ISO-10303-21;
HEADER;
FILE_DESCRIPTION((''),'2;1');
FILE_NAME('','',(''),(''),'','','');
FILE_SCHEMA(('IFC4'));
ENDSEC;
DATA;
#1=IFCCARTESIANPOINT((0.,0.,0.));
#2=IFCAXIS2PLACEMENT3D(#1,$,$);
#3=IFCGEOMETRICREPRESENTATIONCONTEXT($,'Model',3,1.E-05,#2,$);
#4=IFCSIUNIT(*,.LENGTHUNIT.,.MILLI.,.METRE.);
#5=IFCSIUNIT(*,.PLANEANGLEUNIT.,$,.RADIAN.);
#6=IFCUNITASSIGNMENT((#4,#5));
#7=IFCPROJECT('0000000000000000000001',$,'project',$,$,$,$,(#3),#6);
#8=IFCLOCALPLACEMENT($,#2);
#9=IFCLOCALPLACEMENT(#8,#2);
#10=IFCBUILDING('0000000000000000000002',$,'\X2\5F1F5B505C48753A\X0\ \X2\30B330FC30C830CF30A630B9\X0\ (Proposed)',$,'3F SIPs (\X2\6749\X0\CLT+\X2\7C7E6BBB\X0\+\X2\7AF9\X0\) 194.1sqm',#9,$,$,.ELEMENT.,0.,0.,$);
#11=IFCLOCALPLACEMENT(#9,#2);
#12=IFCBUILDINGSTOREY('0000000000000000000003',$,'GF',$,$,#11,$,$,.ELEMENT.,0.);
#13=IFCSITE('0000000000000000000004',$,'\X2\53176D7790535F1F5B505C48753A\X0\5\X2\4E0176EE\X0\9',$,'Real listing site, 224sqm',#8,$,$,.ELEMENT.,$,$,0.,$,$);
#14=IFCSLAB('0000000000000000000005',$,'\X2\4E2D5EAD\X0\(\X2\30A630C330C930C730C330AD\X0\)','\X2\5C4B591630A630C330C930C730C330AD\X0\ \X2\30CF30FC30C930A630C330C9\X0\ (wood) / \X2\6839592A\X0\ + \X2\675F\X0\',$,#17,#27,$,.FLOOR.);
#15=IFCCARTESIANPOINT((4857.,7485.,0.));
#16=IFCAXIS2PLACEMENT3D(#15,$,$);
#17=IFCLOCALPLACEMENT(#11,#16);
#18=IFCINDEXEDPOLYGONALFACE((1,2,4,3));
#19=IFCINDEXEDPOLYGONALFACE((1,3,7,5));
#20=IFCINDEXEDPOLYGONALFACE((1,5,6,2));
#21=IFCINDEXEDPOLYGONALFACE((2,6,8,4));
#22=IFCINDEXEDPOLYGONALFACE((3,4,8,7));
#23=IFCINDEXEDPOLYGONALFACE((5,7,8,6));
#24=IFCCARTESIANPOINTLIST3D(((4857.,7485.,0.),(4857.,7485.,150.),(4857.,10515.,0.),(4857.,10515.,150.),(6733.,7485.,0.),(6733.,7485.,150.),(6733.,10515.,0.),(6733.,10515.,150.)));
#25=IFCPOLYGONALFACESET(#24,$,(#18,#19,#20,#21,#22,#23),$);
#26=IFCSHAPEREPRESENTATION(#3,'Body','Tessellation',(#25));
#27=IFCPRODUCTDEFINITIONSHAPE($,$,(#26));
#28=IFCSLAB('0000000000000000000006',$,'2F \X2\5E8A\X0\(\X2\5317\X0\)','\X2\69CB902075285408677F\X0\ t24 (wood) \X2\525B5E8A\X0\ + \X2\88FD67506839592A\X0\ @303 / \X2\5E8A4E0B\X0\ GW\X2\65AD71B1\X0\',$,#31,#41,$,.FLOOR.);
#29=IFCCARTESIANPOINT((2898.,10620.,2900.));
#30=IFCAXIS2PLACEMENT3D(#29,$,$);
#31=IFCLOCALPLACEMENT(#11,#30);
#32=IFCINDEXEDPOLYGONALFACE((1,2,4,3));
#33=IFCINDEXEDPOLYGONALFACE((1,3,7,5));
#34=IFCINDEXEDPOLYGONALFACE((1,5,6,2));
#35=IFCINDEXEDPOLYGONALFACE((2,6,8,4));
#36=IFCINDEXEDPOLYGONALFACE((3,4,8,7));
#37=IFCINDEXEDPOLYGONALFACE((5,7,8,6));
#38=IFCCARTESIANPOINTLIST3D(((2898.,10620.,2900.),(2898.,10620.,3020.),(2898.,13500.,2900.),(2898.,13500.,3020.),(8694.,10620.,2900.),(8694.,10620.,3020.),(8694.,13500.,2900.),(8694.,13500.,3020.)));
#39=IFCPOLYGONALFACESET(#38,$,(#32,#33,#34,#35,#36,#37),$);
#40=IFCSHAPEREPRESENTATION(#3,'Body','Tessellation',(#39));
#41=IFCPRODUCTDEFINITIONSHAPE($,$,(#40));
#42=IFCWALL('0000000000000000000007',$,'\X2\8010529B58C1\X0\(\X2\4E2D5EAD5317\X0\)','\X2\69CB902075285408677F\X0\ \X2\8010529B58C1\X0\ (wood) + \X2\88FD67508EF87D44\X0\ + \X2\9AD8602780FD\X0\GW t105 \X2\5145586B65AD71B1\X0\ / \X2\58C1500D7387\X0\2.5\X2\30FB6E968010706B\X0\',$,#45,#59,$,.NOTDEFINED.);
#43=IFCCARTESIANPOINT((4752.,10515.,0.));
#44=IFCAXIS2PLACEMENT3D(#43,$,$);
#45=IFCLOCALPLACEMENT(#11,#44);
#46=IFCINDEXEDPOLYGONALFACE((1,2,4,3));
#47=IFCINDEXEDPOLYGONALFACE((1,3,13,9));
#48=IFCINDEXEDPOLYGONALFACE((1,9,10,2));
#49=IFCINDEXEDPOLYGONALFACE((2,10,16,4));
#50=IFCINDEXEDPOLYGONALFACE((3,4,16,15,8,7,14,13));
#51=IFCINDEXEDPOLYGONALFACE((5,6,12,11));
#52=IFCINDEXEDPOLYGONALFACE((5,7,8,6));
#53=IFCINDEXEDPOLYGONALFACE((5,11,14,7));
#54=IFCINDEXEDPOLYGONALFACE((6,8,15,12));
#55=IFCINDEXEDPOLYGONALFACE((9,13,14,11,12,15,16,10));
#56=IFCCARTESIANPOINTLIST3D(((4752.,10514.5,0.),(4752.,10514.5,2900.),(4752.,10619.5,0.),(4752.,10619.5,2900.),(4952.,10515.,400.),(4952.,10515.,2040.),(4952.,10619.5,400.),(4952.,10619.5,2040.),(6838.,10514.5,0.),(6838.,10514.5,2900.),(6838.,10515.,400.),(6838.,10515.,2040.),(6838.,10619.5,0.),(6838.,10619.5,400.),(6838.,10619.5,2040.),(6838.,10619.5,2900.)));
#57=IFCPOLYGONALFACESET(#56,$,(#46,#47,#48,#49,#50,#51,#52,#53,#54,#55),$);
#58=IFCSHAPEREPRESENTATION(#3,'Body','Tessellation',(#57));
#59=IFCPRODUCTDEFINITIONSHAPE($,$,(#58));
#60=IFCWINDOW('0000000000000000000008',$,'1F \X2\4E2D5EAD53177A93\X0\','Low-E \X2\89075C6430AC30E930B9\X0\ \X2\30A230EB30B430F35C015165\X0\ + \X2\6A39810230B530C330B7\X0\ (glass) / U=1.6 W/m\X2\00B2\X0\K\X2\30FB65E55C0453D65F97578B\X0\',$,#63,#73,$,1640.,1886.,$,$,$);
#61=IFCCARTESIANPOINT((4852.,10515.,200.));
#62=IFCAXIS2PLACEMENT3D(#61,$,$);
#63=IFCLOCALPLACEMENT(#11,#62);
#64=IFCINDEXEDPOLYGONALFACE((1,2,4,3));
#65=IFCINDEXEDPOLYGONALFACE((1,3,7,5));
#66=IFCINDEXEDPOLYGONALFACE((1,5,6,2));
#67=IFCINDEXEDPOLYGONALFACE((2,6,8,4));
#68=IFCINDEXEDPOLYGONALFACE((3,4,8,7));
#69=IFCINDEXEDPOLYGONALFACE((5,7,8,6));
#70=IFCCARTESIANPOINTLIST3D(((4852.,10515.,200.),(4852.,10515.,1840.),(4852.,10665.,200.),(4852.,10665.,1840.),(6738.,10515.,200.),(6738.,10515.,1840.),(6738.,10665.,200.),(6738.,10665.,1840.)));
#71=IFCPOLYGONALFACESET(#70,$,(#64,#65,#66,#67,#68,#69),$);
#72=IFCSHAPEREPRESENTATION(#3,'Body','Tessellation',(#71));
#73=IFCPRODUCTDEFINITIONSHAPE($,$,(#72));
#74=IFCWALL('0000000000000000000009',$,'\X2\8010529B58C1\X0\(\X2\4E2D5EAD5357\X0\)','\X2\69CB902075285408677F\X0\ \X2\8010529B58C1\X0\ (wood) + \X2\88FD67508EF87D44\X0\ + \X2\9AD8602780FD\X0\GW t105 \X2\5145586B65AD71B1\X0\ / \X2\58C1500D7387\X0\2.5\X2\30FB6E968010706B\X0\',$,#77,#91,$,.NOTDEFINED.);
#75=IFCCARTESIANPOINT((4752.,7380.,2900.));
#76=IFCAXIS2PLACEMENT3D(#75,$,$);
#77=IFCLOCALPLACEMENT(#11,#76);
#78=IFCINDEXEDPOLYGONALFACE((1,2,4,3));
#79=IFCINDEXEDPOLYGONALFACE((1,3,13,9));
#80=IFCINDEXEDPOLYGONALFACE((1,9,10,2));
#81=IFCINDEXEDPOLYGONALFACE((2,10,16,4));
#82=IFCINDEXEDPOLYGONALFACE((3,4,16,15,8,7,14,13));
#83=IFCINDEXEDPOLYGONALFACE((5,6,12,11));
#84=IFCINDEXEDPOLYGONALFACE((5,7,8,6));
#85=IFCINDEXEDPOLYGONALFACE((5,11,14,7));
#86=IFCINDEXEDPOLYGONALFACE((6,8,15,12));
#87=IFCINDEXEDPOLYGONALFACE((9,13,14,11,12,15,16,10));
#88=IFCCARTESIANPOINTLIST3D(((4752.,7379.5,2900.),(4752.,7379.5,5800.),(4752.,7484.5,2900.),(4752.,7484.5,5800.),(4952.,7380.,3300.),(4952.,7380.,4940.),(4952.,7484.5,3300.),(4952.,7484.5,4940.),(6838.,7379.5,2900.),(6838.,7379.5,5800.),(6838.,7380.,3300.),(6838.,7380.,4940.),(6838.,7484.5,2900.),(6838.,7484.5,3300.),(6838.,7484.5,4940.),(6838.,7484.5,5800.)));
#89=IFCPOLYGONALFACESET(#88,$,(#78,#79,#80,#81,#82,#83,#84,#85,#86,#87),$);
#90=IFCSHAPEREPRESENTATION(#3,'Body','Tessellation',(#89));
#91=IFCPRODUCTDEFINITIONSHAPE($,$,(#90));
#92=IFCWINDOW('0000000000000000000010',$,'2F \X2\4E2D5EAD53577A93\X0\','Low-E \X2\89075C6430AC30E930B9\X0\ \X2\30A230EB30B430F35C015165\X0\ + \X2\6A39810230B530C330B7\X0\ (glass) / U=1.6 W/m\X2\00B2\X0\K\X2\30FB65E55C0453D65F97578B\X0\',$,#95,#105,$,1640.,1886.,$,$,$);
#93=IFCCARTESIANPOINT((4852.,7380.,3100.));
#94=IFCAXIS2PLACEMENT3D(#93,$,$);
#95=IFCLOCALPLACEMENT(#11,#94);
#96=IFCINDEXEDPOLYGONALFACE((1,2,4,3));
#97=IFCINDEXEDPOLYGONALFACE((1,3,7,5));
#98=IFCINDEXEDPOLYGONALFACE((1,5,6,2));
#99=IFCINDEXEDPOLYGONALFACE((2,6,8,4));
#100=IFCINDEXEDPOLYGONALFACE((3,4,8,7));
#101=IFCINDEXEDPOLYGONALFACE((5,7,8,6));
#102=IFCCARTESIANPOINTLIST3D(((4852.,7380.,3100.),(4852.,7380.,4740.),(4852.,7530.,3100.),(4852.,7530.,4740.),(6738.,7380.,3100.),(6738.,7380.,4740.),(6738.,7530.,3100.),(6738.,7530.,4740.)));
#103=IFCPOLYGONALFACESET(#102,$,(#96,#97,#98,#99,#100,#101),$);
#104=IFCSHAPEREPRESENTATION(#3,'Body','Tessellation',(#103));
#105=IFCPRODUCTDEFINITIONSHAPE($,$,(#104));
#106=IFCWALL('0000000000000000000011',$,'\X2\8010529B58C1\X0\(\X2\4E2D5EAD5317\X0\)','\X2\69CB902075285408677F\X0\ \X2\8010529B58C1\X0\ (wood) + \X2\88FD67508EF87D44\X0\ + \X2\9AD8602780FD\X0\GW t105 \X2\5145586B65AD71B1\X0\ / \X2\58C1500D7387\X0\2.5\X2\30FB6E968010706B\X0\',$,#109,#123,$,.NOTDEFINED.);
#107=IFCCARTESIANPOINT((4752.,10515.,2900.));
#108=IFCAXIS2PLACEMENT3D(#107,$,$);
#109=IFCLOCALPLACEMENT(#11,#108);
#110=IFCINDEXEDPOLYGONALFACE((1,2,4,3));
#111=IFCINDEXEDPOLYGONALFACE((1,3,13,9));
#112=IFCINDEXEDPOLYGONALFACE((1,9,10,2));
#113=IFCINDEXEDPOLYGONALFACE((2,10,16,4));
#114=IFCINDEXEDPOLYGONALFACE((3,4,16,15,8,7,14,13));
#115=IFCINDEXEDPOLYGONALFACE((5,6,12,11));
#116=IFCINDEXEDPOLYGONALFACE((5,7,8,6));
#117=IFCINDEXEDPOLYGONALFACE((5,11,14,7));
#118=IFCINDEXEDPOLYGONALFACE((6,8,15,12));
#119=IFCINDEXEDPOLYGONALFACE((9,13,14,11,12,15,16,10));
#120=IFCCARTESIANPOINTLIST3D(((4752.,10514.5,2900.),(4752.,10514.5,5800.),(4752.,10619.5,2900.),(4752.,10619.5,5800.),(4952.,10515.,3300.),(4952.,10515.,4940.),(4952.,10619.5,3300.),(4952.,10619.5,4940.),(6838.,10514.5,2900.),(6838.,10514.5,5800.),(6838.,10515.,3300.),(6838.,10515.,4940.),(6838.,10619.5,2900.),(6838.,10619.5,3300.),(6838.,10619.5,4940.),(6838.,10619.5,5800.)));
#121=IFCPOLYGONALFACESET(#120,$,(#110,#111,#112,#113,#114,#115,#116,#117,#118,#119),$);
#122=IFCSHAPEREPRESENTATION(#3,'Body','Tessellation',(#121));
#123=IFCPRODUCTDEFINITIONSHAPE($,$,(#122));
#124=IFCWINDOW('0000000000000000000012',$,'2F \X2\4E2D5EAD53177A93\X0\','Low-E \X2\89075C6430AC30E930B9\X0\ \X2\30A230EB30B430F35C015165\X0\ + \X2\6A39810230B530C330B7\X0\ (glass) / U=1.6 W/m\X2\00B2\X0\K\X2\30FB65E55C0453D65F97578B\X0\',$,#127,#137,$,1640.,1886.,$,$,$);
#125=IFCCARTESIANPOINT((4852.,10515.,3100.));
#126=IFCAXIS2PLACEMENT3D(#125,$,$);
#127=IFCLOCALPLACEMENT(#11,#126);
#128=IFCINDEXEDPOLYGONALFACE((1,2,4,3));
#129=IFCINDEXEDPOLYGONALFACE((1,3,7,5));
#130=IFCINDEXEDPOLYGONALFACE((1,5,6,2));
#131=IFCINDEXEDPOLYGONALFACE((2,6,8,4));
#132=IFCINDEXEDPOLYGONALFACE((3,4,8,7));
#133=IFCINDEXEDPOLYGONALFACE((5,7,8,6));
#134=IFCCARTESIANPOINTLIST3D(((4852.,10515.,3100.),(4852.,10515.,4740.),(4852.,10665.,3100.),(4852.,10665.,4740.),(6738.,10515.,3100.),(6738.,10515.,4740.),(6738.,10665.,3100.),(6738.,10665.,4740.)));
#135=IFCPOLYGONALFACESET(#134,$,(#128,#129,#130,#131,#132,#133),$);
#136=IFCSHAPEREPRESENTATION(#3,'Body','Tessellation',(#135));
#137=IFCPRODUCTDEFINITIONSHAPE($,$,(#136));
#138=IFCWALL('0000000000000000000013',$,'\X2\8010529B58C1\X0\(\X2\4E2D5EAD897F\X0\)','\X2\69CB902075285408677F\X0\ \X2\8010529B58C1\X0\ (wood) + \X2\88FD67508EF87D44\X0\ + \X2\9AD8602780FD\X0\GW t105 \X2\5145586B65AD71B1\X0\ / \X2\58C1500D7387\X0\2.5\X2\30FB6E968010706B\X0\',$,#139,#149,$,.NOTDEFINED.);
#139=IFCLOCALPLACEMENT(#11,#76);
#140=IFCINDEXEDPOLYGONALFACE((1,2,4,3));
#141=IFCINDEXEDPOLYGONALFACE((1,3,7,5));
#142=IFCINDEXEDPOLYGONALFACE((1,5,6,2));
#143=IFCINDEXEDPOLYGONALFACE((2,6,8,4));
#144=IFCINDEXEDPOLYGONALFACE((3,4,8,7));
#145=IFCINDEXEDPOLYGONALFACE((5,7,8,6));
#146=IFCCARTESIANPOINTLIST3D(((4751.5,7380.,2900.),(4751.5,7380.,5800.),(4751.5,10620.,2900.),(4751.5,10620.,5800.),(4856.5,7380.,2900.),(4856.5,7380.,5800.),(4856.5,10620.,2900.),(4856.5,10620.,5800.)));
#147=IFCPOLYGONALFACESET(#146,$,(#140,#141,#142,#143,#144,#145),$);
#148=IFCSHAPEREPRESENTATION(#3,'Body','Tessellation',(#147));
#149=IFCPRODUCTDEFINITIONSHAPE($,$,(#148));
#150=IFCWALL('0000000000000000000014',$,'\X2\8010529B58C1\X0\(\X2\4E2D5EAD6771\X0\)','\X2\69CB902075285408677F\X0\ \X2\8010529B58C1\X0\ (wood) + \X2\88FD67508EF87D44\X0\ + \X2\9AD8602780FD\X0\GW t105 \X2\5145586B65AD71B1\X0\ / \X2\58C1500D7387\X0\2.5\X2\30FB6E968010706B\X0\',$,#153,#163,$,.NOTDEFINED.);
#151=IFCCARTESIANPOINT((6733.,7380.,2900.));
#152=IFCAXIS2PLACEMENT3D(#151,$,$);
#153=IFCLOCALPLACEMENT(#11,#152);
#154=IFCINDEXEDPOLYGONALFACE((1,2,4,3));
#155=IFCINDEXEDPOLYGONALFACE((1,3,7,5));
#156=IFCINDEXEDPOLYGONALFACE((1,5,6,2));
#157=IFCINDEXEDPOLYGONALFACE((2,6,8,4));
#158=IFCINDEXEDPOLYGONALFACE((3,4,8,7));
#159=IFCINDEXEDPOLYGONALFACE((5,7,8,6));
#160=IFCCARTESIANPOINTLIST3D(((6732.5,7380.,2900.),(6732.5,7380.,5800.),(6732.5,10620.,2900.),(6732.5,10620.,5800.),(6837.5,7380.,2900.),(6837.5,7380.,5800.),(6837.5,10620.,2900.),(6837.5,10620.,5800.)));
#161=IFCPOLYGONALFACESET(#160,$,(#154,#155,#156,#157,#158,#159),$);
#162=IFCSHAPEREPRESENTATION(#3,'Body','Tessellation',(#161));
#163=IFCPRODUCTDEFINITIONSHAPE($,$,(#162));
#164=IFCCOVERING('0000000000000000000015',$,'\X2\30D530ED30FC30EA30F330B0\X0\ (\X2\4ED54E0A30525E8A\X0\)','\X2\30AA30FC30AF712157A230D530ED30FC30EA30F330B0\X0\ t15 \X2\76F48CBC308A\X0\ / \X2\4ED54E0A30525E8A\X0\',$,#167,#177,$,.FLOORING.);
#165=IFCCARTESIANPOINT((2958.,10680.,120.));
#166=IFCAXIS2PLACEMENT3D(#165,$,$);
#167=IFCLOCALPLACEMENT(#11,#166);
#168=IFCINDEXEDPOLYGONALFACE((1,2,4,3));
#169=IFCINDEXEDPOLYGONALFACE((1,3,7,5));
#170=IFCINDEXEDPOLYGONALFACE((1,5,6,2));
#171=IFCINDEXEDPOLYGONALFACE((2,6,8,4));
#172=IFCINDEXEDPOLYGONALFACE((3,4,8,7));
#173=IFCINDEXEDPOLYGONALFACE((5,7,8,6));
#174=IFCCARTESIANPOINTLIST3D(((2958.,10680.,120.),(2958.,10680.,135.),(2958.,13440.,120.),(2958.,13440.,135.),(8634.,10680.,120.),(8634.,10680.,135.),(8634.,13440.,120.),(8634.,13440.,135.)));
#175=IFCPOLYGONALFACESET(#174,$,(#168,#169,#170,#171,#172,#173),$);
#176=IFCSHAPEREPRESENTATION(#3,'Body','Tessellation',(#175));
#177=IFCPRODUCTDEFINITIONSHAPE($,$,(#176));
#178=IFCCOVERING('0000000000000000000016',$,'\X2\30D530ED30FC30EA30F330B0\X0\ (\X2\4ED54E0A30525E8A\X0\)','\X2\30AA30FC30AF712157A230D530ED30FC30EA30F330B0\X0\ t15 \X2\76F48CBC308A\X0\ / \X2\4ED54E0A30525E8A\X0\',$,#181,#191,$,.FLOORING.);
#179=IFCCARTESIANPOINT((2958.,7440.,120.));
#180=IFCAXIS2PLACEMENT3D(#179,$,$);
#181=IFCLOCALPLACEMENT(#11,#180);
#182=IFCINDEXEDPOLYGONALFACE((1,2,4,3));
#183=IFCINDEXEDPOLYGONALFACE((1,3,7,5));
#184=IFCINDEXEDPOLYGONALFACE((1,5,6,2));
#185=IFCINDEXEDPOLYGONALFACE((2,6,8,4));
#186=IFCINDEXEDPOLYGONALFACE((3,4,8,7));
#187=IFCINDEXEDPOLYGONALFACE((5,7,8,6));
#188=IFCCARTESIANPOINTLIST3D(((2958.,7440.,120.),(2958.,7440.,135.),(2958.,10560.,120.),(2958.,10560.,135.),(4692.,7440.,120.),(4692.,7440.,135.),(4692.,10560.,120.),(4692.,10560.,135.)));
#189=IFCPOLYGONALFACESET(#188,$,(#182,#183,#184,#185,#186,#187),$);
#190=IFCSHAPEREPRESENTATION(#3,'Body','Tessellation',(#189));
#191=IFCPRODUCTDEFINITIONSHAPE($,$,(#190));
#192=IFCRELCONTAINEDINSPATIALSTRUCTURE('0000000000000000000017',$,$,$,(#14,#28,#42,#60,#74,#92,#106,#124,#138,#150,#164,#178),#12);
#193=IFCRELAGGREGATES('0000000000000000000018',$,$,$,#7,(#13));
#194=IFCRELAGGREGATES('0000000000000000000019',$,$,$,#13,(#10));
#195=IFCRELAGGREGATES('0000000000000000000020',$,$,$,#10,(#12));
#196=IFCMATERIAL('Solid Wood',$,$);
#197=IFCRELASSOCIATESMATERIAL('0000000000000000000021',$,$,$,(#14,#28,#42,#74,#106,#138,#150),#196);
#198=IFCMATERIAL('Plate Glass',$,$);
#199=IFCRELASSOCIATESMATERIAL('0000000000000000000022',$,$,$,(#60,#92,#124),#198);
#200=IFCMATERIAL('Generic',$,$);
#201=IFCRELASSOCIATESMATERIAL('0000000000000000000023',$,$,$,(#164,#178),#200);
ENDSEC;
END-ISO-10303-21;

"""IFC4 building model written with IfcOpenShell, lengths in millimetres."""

from ifc_helpers import new_model, si_unit, frame, frame_2d, origin, place, context, project, spatial, rectangle, extrude, material, element, fill, save


model = new_model("IFC4")

# Units and contexts
model_context = context("Model", 3, precision=1e-05, world=origin())
ifc_project = project(units=[si_unit("LENGTHUNIT", "METRE", prefix="MILLI"), si_unit("PLANEANGLEUNIT", "RADIAN")], contexts=[model_context])

# Site, building, storey
site_placement = place(None, origin())
site = spatial("IfcSite", under=ifc_project, at=site_placement, Name="北海道弟子屈町5丁目9", ObjectType="Real listing site, 224sqm", CompositionType="ELEMENT", RefElevation=0.0)
building_placement = place(site_placement, origin())
building = spatial("IfcBuilding", under=site, at=building_placement, Name="弟子屈町 コートハウス (Proposed)", ObjectType="3F SIPs (杉CLT+籾殻+竹) 194.1sqm", CompositionType="ELEMENT", ElevationOfRefHeight=0.0, ElevationOfTerrain=0.0)
storey_placement = place(building_placement, origin())
storey = spatial("IfcBuildingStorey", under=building, at=storey_placement, Name="GF", CompositionType="ELEMENT", Elevation=0.0)

# Slabs
ifc_material_1 = material(Name="Solid Wood")
slab_1_placement = place(storey_placement, frame((4857.0, 7485.0, 0.0)))
element("IfcSlab", 1, at=slab_1_placement, inside=storey, material=ifc_material_1, Name="中庭(ウッドデッキ)", Description="屋外ウッドデッキ ハードウッド (wood) / 根太 + 束", PredefinedType="FLOOR", context=model_context, shape_type="SweptSolid", body=[
    extrude(rectangle(XDim=1876.0, YDim=3030.0, at=frame_2d((938.0, 1515.0))), frame((4857.0, 7485.0, 0.0)), (0.0, 0.0, 1.0), 150.0),
])
slab_2_placement = place(storey_placement, frame((2898.0, 10620.0, 2900.0)))
element("IfcSlab", 2, at=slab_2_placement, inside=storey, material=ifc_material_1, Name="2F 床(北)", Description="構造用合板 t24 (wood) 剛床 + 製材根太 @303 / 床下 GW断熱", PredefinedType="FLOOR", context=model_context, shape_type="SweptSolid", body=[
    extrude(rectangle(XDim=5796.0, YDim=2880.0, at=frame_2d((2898.0, 1440.0))), frame((2898.0, 10620.0, 2900.0)), (0.0, 0.0, 1.0), 120.0),
])

# Wall, opening, window
wall_1_placement = place(storey_placement, frame((4752.0, 10515.0, 0.0)))
wall_1 = element("IfcWall", 3, at=wall_1_placement, inside=storey, material=ifc_material_1, Name="耐力壁(中庭北)", Description="構造用合板 耐力壁 (wood) + 製材軸組 + 高性能GW t105 充填断熱 / 壁倍率2.5・準耐火", PredefinedType="NOTDEFINED", context=model_context, shape_type="SweptSolid", body=[
    extrude(rectangle(XDim=2086.0, YDim=105.0, at=frame_2d((1043.0, 52.0))), frame((4752.0, 10515.0, 0.0)), (0.0, 0.0, 1.0), 2900.0),
])
opening_1_placement = place(storey_placement, frame((4852.0, 10515.0, 200.0)))
opening_1 = element("IfcOpeningElement", 4, at=opening_1_placement, cuts=wall_1, PredefinedType="NOTDEFINED", context=model_context, shape_type="SweptSolid", body=[
    extrude(rectangle(XDim=1886.0, YDim=150.0, at=frame_2d((943.0, 75.0))), frame((4852.0, 10515.0, 200.0)), (0.0, 0.0, 1.0), 1640.0),
])
ifc_material_2 = material(Name="Plate Glass")
window_1_placement = place(storey_placement, frame((4852.0, 10515.0, 200.0)))
window_1 = element("IfcWindow", 5, at=window_1_placement, inside=storey, material=ifc_material_2, Name="1F 中庭北窓", Description="Low-E 複層ガラス アルゴン封入 + 樹脂サッシ (glass) / U=1.6 W/m²K・日射取得型", OverallHeight=1640.0, OverallWidth=1886.0, context=model_context, shape_type="SweptSolid", body=[
    extrude(rectangle(XDim=1886.0, YDim=150.0, at=frame_2d((943.0, 75.0))), frame((4852.0, 10515.0, 200.0)), (0.0, 0.0, 1.0), 1640.0),
])
fill(opening_1, window_1)

# Walls, openings, windows
wall_2_placement = place(storey_placement, frame((4752.0, 7380.0, 2900.0)))
wall_2 = element("IfcWall", 6, at=wall_2_placement, inside=storey, material=ifc_material_1, Name="耐力壁(中庭南)", Description="構造用合板 耐力壁 (wood) + 製材軸組 + 高性能GW t105 充填断熱 / 壁倍率2.5・準耐火", PredefinedType="NOTDEFINED", context=model_context, shape_type="SweptSolid", body=[
    extrude(rectangle(XDim=2086.0, YDim=105.0, at=frame_2d((1043.0, 52.0))), frame((4752.0, 7380.0, 2900.0)), (0.0, 0.0, 1.0), 2900.0),
])
opening_2_placement = place(storey_placement, frame((4852.0, 7380.0, 3100.0)))
opening_2 = element("IfcOpeningElement", 7, at=opening_2_placement, cuts=wall_2, PredefinedType="NOTDEFINED", context=model_context, shape_type="SweptSolid", body=[
    extrude(rectangle(XDim=1886.0, YDim=150.0, at=frame_2d((943.0, 75.0))), frame((4852.0, 7380.0, 3100.0)), (0.0, 0.0, 1.0), 1640.0),
])
window_2_placement = place(storey_placement, frame((4852.0, 7380.0, 3100.0)))
window_2 = element("IfcWindow", 8, at=window_2_placement, inside=storey, material=ifc_material_2, Name="2F 中庭南窓", Description="Low-E 複層ガラス アルゴン封入 + 樹脂サッシ (glass) / U=1.6 W/m²K・日射取得型", OverallHeight=1640.0, OverallWidth=1886.0, context=model_context, shape_type="SweptSolid", body=[
    extrude(rectangle(XDim=1886.0, YDim=150.0, at=frame_2d((943.0, 75.0))), frame((4852.0, 7380.0, 3100.0)), (0.0, 0.0, 1.0), 1640.0),
])
fill(opening_2, window_2)
wall_3_placement = place(storey_placement, frame((4752.0, 10515.0, 2900.0)))
wall_3 = element("IfcWall", 9, at=wall_3_placement, inside=storey, material=ifc_material_1, Name="耐力壁(中庭北)", Description="構造用合板 耐力壁 (wood) + 製材軸組 + 高性能GW t105 充填断熱 / 壁倍率2.5・準耐火", PredefinedType="NOTDEFINED", context=model_context, shape_type="SweptSolid", body=[
    extrude(rectangle(XDim=2086.0, YDim=105.0, at=frame_2d((1043.0, 52.0))), frame((4752.0, 10515.0, 2900.0)), (0.0, 0.0, 1.0), 2900.0),
])
opening_3_placement = place(storey_placement, frame((4852.0, 10515.0, 3100.0)))
opening_3 = element("IfcOpeningElement", 10, at=opening_3_placement, cuts=wall_3, PredefinedType="NOTDEFINED", context=model_context, shape_type="SweptSolid", body=[
    extrude(rectangle(XDim=1886.0, YDim=150.0, at=frame_2d((943.0, 75.0))), frame((4852.0, 10515.0, 3100.0)), (0.0, 0.0, 1.0), 1640.0),
])
window_3_placement = place(storey_placement, frame((4852.0, 10515.0, 3100.0)))
window_3 = element("IfcWindow", 11, at=window_3_placement, inside=storey, material=ifc_material_2, Name="2F 中庭北窓", Description="Low-E 複層ガラス アルゴン封入 + 樹脂サッシ (glass) / U=1.6 W/m²K・日射取得型", OverallHeight=1640.0, OverallWidth=1886.0, context=model_context, shape_type="SweptSolid", body=[
    extrude(rectangle(XDim=1886.0, YDim=150.0, at=frame_2d((943.0, 75.0))), frame((4852.0, 10515.0, 3100.0)), (0.0, 0.0, 1.0), 1640.0),
])
fill(opening_3, window_3)

# Walls
wall_4_placement = place(storey_placement, frame((4752.0, 7380.0, 2900.0)))
element("IfcWall", 12, at=wall_4_placement, inside=storey, material=ifc_material_1, Name="耐力壁(中庭西)", Description="構造用合板 耐力壁 (wood) + 製材軸組 + 高性能GW t105 充填断熱 / 壁倍率2.5・準耐火", PredefinedType="NOTDEFINED", context=model_context, shape_type="SweptSolid", body=[
    extrude(rectangle(XDim=105.0, YDim=3240.0, at=frame_2d((52.0, 1620.0))), frame((4752.0, 7380.0, 2900.0)), (0.0, 0.0, 1.0), 2900.0),
])
wall_5_placement = place(storey_placement, frame((6733.0, 7380.0, 2900.0)))
element("IfcWall", 13, at=wall_5_placement, inside=storey, material=ifc_material_1, Name="耐力壁(中庭東)", Description="構造用合板 耐力壁 (wood) + 製材軸組 + 高性能GW t105 充填断熱 / 壁倍率2.5・準耐火", PredefinedType="NOTDEFINED", context=model_context, shape_type="SweptSolid", body=[
    extrude(rectangle(XDim=105.0, YDim=3240.0, at=frame_2d((52.0, 1620.0))), frame((6733.0, 7380.0, 2900.0)), (0.0, 0.0, 1.0), 2900.0),
])

# Coverings
ifc_material_3 = material(Name="Generic")
covering_1_placement = place(storey_placement, frame((2958.0, 10680.0, 120.0)))
element("IfcCovering", 14, at=covering_1_placement, inside=storey, material=ifc_material_3, Name="フローリング (仕上げ床)", Description="オーク無垢フローリング t15 直貼り / 仕上げ床", PredefinedType="FLOORING", context=model_context, shape_type="SweptSolid", body=[
    extrude(rectangle(XDim=5676.0, YDim=2760.0, at=frame_2d((2838.0, 1380.0))), frame((2958.0, 10680.0, 120.0)), (0.0, 0.0, 1.0), 15.0),
])
covering_2_placement = place(storey_placement, frame((2958.0, 7440.0, 120.0)))
element("IfcCovering", 15, at=covering_2_placement, inside=storey, material=ifc_material_3, Name="フローリング (仕上げ床)", Description="オーク無垢フローリング t15 直貼り / 仕上げ床", PredefinedType="FLOORING", context=model_context, shape_type="SweptSolid", body=[
    extrude(rectangle(XDim=1734.0, YDim=3120.0, at=frame_2d((867.0, 1560.0))), frame((2958.0, 7440.0, 120.0)), (0.0, 0.0, 1.0), 15.0),
])

save(model, "model.ifc")
